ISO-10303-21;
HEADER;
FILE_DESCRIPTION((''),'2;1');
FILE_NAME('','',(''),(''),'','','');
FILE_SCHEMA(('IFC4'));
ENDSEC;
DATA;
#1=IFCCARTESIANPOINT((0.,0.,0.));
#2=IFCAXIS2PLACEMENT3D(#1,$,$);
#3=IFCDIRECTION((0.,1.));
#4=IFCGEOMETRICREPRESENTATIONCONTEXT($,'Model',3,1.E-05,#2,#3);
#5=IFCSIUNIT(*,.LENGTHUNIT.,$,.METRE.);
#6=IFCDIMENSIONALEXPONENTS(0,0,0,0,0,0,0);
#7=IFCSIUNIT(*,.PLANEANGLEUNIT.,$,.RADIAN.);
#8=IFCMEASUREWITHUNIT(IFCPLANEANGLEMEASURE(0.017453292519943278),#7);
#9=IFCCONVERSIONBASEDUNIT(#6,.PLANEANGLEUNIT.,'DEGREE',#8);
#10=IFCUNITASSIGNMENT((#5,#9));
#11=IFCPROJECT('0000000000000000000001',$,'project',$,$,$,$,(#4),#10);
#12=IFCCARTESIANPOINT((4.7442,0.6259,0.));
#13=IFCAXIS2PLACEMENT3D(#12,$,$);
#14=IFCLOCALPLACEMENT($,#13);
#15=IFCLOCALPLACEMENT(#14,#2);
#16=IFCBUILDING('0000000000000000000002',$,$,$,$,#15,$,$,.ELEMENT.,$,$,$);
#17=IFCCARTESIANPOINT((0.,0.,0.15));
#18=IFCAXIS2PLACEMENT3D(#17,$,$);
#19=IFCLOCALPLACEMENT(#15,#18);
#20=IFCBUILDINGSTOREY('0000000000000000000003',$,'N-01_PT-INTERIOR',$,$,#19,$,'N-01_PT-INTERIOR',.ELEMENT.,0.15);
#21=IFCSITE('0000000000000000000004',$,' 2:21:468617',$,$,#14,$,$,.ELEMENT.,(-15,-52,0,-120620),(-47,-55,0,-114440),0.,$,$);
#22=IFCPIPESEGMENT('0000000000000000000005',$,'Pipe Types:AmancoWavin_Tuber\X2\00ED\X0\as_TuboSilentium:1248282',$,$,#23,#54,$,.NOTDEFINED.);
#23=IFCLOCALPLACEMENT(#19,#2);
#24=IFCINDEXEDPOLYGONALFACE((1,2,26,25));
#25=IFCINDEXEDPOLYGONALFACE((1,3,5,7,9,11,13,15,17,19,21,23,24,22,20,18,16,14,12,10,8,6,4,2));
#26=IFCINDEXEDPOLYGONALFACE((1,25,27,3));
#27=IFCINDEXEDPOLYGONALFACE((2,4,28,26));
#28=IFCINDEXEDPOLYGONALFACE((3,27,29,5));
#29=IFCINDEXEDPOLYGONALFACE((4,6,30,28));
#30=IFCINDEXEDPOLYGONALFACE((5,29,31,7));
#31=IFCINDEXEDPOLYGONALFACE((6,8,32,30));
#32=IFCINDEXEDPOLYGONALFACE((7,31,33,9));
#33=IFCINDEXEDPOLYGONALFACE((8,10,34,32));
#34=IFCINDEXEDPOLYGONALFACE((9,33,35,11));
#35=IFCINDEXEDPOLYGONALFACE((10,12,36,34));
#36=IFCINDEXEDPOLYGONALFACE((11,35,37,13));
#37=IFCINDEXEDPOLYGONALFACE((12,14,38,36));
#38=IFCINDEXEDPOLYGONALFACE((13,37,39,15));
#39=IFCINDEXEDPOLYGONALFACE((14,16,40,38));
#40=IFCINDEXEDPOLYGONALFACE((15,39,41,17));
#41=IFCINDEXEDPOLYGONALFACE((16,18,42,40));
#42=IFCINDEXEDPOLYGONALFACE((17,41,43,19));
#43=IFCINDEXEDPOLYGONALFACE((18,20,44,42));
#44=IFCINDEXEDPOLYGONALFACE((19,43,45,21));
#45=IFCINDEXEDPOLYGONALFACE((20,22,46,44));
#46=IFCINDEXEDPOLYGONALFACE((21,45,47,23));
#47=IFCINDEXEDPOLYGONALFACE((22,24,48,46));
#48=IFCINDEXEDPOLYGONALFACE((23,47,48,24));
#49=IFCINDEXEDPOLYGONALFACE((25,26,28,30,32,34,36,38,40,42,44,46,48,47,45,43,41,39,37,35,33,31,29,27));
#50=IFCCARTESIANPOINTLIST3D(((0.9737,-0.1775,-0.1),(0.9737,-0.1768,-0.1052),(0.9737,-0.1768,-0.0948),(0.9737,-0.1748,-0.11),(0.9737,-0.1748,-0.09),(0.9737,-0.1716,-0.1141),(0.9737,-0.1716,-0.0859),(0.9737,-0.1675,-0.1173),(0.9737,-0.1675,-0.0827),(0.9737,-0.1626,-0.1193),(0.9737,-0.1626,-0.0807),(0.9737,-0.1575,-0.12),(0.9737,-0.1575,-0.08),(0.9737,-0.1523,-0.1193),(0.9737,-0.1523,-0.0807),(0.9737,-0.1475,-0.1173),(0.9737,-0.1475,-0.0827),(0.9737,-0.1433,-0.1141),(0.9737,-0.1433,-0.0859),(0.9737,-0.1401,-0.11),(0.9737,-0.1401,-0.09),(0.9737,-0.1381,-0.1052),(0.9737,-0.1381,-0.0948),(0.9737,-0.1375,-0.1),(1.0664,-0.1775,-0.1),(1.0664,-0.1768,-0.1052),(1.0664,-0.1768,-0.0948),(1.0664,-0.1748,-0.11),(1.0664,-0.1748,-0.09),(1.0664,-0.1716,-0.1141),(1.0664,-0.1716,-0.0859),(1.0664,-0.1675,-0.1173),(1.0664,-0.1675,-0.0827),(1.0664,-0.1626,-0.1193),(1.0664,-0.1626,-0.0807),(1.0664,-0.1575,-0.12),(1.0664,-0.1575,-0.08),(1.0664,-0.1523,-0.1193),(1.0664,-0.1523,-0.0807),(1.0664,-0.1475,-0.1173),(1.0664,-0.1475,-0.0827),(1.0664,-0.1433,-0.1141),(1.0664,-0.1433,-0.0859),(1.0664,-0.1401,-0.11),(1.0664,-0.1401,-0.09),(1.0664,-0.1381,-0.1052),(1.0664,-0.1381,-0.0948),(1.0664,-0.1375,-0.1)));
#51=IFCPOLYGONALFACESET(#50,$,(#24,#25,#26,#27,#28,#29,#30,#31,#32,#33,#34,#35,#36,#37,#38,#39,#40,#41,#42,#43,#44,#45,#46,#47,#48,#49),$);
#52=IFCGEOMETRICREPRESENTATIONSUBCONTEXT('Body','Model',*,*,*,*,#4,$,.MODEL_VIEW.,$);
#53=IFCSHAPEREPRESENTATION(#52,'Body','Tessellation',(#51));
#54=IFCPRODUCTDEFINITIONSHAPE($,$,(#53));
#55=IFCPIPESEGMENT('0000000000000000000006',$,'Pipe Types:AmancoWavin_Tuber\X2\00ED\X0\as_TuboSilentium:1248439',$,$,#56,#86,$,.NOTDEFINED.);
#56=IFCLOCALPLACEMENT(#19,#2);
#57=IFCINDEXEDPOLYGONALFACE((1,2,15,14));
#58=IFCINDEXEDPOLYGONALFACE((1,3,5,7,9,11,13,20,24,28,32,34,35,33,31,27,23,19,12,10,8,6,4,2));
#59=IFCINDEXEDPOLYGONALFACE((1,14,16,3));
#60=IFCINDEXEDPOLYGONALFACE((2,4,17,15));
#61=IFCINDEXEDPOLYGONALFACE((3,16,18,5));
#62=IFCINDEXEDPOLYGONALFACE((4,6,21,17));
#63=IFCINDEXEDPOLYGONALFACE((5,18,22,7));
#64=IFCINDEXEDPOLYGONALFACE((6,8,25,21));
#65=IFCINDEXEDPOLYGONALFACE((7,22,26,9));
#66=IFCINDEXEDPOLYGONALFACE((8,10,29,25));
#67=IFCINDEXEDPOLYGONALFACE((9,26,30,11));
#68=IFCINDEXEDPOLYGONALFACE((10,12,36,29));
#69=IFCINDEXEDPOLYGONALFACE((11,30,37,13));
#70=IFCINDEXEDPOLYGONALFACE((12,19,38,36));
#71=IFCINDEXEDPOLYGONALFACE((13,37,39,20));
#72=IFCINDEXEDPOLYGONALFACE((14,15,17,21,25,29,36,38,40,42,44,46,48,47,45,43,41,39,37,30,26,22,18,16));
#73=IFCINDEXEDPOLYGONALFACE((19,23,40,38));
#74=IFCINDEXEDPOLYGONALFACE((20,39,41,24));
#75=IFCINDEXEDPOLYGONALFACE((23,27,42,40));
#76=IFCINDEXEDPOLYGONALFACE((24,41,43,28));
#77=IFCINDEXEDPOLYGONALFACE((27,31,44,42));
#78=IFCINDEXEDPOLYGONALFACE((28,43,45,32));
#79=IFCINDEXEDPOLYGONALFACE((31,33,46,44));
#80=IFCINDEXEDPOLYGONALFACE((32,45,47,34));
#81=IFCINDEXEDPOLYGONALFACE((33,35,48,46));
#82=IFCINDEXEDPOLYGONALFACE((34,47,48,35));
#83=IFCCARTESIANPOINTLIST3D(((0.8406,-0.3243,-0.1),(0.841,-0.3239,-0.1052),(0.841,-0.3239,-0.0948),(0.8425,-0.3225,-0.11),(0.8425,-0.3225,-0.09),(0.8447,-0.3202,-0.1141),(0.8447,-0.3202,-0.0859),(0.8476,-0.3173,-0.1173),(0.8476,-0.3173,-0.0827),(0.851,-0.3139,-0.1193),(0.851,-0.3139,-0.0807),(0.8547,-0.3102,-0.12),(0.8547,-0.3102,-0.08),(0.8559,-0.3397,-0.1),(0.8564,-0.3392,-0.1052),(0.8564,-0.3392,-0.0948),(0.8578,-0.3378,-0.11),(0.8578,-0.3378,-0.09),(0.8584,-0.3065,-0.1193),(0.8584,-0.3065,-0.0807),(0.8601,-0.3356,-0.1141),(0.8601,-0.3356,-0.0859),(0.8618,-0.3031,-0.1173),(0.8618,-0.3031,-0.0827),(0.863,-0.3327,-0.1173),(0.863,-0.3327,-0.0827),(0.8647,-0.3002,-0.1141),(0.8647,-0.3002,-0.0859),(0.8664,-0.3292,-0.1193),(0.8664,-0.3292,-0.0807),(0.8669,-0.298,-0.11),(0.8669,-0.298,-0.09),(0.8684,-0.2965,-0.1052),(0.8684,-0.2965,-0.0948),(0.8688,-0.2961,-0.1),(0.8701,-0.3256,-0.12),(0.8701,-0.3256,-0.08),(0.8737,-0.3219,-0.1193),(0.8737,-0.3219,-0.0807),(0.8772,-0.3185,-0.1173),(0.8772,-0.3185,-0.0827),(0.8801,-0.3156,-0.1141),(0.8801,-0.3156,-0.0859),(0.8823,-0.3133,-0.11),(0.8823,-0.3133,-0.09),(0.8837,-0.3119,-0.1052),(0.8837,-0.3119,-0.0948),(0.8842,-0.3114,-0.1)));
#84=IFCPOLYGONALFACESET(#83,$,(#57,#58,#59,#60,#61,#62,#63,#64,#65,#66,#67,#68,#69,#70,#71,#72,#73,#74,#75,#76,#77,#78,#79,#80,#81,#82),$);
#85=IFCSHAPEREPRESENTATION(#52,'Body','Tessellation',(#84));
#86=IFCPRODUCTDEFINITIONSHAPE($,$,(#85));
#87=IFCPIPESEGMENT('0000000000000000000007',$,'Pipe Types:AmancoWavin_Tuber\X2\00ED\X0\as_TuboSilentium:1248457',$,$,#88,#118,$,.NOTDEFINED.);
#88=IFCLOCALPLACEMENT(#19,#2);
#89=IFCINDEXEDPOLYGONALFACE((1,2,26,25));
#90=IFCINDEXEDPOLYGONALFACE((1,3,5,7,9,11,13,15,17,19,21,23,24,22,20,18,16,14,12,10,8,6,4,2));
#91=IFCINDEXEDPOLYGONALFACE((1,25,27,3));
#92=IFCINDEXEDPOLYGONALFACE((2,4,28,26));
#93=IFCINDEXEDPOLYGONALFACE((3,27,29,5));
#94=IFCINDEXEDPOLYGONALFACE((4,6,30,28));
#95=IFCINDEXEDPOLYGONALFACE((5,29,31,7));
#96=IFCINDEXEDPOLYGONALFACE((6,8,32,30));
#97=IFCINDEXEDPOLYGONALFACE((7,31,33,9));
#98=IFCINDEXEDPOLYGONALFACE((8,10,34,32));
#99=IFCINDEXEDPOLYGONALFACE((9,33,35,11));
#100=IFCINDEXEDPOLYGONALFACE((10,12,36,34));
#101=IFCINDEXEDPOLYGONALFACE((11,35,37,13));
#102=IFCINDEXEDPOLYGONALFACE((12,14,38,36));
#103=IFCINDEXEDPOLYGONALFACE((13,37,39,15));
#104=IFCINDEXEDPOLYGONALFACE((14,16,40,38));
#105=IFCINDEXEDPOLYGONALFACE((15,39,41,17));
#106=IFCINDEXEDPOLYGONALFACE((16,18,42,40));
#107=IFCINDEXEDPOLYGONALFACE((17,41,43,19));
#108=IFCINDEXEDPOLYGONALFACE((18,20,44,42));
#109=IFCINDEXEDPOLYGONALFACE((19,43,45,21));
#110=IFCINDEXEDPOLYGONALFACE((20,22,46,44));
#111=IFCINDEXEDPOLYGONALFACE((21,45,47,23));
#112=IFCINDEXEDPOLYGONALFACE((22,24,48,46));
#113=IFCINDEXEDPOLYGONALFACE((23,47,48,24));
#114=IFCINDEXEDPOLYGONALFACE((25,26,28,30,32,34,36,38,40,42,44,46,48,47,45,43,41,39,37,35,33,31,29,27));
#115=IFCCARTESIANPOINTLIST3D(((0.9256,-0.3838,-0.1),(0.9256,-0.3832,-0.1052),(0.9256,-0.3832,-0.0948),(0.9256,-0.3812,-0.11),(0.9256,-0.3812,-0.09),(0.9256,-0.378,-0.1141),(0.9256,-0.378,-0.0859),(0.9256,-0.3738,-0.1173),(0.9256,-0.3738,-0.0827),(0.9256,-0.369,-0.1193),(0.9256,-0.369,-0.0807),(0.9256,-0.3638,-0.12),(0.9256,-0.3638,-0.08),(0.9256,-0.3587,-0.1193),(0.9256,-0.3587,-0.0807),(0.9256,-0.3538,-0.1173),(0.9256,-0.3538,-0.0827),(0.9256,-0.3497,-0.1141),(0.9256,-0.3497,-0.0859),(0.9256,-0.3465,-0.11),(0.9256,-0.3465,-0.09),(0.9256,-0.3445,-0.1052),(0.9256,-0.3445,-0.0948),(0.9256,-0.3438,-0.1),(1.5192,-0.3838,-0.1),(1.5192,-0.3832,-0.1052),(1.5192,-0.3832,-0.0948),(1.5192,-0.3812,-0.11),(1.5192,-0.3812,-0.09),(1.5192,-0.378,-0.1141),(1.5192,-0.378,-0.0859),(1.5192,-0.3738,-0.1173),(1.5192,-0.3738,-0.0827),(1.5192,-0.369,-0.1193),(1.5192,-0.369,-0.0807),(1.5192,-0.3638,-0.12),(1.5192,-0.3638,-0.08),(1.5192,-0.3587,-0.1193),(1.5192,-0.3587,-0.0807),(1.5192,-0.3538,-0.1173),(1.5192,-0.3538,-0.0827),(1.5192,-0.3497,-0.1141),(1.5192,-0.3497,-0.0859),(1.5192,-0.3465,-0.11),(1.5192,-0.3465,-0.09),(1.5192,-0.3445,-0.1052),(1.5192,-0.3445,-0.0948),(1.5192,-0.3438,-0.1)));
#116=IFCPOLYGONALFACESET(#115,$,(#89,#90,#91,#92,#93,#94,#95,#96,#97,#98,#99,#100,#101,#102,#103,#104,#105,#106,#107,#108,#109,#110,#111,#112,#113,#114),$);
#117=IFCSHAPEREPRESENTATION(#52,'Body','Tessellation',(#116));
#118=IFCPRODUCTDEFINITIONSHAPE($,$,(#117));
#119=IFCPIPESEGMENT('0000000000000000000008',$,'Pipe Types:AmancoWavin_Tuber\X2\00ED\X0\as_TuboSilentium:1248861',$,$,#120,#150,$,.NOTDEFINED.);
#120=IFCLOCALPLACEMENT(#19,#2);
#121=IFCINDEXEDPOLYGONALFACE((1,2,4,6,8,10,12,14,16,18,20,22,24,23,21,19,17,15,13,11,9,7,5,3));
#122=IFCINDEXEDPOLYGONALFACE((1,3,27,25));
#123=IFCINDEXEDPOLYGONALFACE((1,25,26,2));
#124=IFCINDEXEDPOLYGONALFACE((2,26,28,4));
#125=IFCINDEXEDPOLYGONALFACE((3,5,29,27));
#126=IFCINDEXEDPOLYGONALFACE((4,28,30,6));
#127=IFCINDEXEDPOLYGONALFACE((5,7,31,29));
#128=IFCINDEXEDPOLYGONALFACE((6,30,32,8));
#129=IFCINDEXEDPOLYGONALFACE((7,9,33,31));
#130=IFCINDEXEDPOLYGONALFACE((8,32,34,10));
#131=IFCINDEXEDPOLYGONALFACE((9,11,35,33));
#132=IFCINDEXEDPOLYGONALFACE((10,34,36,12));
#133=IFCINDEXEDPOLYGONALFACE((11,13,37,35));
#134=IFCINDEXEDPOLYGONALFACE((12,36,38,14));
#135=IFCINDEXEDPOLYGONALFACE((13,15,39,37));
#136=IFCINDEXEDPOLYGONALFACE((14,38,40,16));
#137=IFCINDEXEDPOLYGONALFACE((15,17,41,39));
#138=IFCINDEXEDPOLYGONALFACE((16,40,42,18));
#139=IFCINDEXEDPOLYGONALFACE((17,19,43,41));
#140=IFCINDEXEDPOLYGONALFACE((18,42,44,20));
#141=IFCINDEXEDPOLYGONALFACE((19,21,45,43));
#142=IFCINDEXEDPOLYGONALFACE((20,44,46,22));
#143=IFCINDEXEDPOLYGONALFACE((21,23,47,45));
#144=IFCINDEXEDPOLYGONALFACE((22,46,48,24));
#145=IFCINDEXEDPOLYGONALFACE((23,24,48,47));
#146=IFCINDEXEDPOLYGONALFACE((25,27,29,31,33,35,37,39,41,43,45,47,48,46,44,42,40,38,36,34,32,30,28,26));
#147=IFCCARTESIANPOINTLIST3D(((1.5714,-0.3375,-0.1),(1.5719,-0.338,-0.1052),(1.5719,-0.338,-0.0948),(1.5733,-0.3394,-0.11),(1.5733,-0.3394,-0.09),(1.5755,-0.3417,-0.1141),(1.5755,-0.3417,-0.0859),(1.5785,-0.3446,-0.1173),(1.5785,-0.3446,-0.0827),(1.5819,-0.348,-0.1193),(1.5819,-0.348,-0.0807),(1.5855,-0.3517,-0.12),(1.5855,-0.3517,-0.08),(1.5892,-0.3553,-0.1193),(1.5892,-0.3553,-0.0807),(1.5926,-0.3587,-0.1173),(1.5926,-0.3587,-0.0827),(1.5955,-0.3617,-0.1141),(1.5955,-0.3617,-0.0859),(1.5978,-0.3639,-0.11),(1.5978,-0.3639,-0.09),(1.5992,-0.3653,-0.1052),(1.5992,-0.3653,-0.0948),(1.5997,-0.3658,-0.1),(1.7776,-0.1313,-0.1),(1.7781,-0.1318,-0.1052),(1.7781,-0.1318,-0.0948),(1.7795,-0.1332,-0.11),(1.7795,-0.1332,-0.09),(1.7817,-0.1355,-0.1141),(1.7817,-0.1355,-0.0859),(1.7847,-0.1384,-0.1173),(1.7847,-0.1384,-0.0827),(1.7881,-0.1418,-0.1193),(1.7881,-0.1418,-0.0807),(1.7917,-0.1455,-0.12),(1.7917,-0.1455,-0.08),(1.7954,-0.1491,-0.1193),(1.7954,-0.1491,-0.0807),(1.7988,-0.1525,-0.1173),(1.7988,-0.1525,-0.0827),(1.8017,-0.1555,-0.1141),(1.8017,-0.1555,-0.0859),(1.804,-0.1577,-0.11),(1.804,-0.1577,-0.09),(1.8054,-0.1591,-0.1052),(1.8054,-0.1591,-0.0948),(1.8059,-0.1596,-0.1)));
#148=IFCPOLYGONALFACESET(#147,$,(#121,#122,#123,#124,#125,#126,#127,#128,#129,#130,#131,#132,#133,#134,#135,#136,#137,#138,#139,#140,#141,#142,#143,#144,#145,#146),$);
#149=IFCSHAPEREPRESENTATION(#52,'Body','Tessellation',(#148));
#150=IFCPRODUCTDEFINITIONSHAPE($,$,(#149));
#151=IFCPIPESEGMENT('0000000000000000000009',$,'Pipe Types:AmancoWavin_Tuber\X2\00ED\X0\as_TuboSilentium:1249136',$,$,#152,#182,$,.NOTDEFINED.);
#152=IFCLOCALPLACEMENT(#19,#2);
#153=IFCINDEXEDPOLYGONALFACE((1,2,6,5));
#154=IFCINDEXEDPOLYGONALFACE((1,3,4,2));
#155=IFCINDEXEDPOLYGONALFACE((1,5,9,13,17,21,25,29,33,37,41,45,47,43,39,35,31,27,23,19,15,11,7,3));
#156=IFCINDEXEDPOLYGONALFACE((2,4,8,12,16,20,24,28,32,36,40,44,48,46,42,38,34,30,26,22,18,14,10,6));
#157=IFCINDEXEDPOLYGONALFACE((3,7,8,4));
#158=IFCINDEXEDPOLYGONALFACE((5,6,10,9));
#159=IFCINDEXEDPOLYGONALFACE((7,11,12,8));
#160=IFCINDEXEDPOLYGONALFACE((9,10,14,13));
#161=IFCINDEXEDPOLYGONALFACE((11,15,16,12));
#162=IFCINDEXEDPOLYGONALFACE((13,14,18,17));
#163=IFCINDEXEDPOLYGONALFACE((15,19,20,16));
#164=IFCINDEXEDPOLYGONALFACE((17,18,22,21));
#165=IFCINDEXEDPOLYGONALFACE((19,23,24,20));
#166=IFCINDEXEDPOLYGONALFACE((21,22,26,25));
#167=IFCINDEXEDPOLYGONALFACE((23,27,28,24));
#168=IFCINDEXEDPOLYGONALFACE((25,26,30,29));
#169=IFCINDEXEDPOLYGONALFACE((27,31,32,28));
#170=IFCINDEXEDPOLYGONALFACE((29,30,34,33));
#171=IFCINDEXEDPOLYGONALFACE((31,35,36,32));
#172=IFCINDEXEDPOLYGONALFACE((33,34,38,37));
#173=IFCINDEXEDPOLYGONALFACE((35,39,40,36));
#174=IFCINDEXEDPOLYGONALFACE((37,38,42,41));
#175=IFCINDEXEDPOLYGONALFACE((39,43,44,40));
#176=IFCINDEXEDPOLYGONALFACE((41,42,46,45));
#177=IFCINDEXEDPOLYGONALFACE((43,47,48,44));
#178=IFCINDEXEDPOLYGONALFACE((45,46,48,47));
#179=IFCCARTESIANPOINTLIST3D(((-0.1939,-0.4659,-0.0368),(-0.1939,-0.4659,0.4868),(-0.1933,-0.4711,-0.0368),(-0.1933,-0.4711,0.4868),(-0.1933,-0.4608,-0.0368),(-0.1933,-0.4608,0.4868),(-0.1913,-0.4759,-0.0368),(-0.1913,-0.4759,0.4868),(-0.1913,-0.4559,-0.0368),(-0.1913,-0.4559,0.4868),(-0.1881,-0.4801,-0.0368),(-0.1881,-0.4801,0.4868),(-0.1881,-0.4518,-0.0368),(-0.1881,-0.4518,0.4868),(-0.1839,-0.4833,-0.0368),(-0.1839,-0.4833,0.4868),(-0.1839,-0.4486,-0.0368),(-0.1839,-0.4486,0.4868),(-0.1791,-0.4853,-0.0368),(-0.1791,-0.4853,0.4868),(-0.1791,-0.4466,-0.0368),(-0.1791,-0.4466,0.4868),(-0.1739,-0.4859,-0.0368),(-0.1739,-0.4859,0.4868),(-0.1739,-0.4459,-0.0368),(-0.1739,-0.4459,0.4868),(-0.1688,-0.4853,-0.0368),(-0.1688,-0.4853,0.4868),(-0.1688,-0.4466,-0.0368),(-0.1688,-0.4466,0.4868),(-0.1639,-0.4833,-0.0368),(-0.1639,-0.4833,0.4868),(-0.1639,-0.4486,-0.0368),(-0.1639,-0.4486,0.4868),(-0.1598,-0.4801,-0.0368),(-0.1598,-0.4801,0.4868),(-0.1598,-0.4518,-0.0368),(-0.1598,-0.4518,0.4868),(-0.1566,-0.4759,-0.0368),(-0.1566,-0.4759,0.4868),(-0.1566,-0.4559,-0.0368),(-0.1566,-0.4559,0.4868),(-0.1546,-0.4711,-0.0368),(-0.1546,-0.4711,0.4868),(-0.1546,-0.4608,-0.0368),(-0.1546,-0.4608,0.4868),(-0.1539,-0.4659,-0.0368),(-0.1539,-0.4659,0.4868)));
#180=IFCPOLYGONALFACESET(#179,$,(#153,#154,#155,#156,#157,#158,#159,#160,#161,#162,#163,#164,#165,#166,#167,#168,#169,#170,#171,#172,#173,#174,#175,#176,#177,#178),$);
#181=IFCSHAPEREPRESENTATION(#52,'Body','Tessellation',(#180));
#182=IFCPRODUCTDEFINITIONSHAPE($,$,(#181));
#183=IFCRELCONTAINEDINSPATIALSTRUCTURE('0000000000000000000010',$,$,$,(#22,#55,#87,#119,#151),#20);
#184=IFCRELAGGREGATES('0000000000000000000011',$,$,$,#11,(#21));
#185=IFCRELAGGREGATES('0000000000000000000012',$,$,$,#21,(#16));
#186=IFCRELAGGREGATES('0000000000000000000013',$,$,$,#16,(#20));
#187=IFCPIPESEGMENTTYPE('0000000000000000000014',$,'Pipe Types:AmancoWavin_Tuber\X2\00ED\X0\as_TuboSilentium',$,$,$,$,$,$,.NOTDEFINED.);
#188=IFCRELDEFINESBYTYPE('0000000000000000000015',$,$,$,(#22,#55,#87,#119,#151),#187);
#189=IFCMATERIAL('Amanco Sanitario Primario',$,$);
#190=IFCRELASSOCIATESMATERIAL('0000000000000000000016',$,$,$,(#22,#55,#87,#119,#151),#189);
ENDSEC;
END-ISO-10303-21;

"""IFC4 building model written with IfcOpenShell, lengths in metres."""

from ifc_helpers import new_model, entity, si_unit, converted_unit, direction, frame, origin, place, context, subcontext, project, spatial, arc, indexed_curve, outline, extrude, material, type_object, element, save


model = new_model("IFC4")

# Units and contexts
model_context = context("Model", 3, precision=1e-05, world=origin(), true_north=direction((0.0, 1.0)))
body_context = subcontext(model_context, "Body", "Model", "MODEL_VIEW")
ifc_project = project(units=[si_unit("LENGTHUNIT", "METRE"), converted_unit("PLANEANGLEUNIT", "DEGREE", entity("IfcPlaneAngleMeasure", 0.017453292519943278), si_unit("PLANEANGLEUNIT", "RADIAN"), dimensions=[0, 0, 0, 0, 0, 0, 0])], contexts=[model_context])

# Site, building, storey
site_placement = place(None, frame((4.7442, 0.6259, 0.0)))
site = spatial("IfcSite", under=ifc_project, at=site_placement, Name=" 2:21:468617", CompositionType="ELEMENT", RefLatitude=(-15, -52, 0, -120620), RefLongitude=(-47, -55, 0, -114440), RefElevation=0.0)
building_placement = place(site_placement, origin())
building = spatial("IfcBuilding", under=site, at=building_placement, CompositionType="ELEMENT")
storey_placement = place(building_placement, frame((0.0, 0.0, 0.15)))
storey = spatial("IfcBuildingStorey", under=building, at=storey_placement, Name="N-01_PT-INTERIOR", LongName="N-01_PT-INTERIOR", CompositionType="ELEMENT", Elevation=0.15)

# Pipe segments
pipe_segment_type_1 = type_object("IfcPipeSegmentType", Name="Pipe Types:AmancoWavin_Tuberías_TuboSilentium", PredefinedType="NOTDEFINED")
ifc_material_1 = material(Name="Amanco Sanitario Primario")
pipe_segment_1_placement = place(storey_placement, origin())
element("IfcPipeSegment", 1, at=pipe_segment_1_placement, inside=storey, type_object=pipe_segment_type_1, material=ifc_material_1, Name="Pipe Types:AmancoWavin_Tuberías_TuboSilentium:1248282", PredefinedType="NOTDEFINED", context=body_context, shape_type="SweptSolid", body=[
    extrude(outline(indexed_curve([(0.02, 0.0), (0.0141, 0.0141), (0.0, 0.02), (-0.0141, 0.0141), (-0.02, 0.0), (-0.0141, -0.0141), (0.0, -0.02), (0.0141, -0.0141)], segments=[arc(1, 2, 3), arc(3, 4, 5), arc(5, 6, 7), arc(7, 8, 1)], self_intersect=False)), frame((0.9737, -0.1575, -0.1), z_axis=(1.0, 0.0, 0.0), x_axis=(0.0, -1.0, 0.0)), (0.0, 0.0, 1.0), 0.0927),
])
pipe_segment_2_placement = place(storey_placement, origin())
element("IfcPipeSegment", 2, at=pipe_segment_2_placement, inside=storey, type_object=pipe_segment_type_1, material=ifc_material_1, Name="Pipe Types:AmancoWavin_Tuberías_TuboSilentium:1248439", PredefinedType="NOTDEFINED", context=body_context, shape_type="SweptSolid", body=[
    extrude(outline(indexed_curve([(0.02, 0.0), (0.0141, 0.0141), (0.0, 0.02), (-0.0141, 0.0141), (-0.02, 0.0), (-0.0141, -0.0141), (0.0, -0.02), (0.0141, -0.0141)], segments=[arc(1, 2, 3), arc(3, 4, 5), arc(5, 6, 7), arc(7, 8, 1)], self_intersect=False)), frame((0.8701, -0.3256, -0.1), z_axis=(-0.707107, 0.707107, 0.0), x_axis=(-0.707107, -0.707107, 0.0)), (0.0, 0.0, 1.0), 0.0218),
])
pipe_segment_3_placement = place(storey_placement, origin())
element("IfcPipeSegment", 3, at=pipe_segment_3_placement, inside=storey, type_object=pipe_segment_type_1, material=ifc_material_1, Name="Pipe Types:AmancoWavin_Tuberías_TuboSilentium:1248457", PredefinedType="NOTDEFINED", context=body_context, shape_type="SweptSolid", body=[
    extrude(outline(indexed_curve([(0.02, 0.0), (0.0141, 0.0141), (0.0, 0.02), (-0.0141, 0.0141), (-0.02, 0.0), (-0.0141, -0.0141), (0.0, -0.02), (0.0141, -0.0141)], segments=[arc(1, 2, 3), arc(3, 4, 5), arc(5, 6, 7), arc(7, 8, 1)], self_intersect=False)), frame((0.9256, -0.3638, -0.1), z_axis=(1.0, 0.0, 0.0), x_axis=(0.0, -1.0, 0.0)), (0.0, 0.0, 1.0), 0.5937),
])
pipe_segment_4_placement = place(storey_placement, origin())
element("IfcPipeSegment", 4, at=pipe_segment_4_placement, inside=storey, type_object=pipe_segment_type_1, material=ifc_material_1, Name="Pipe Types:AmancoWavin_Tuberías_TuboSilentium:1248861", PredefinedType="NOTDEFINED", context=body_context, shape_type="SweptSolid", body=[
    extrude(outline(indexed_curve([(0.02, 0.0), (0.0141, 0.0141), (0.0, 0.02), (-0.0141, 0.0141), (-0.02, 0.0), (-0.0141, -0.0141), (0.0, -0.02), (0.0141, -0.0141)], segments=[arc(1, 2, 3), arc(3, 4, 5), arc(5, 6, 7), arc(7, 8, 1)], self_intersect=False)), frame((1.5855, -0.3517, -0.1), z_axis=(0.707107, 0.707107, 0.0), x_axis=(0.707107, -0.707107, 0.0)), (0.0, 0.0, 1.0), 0.2916),
])
pipe_segment_5_placement = place(storey_placement, origin())
element("IfcPipeSegment", 5, at=pipe_segment_5_placement, inside=storey, type_object=pipe_segment_type_1, material=ifc_material_1, Name="Pipe Types:AmancoWavin_Tuberías_TuboSilentium:1249136", PredefinedType="NOTDEFINED", context=body_context, shape_type="SweptSolid", body=[
    extrude(outline(indexed_curve([(0.02, 0.0), (0.0141, 0.0141), (0.0, 0.02), (-0.0141, 0.0141), (-0.02, 0.0), (-0.0141, -0.0141), (0.0, -0.02), (0.0141, -0.0141)], segments=[arc(1, 2, 3), arc(3, 4, 5), arc(5, 6, 7), arc(7, 8, 1)], self_intersect=False)), frame((-0.1739, -0.4659, -0.0368), z_axis=(0.0, 0.0, 1.0), x_axis=(-1.0, 0.0, 0.0)), (0.0, 0.0, 1.0), 0.5236),
])

save(model, "model.ifc")
